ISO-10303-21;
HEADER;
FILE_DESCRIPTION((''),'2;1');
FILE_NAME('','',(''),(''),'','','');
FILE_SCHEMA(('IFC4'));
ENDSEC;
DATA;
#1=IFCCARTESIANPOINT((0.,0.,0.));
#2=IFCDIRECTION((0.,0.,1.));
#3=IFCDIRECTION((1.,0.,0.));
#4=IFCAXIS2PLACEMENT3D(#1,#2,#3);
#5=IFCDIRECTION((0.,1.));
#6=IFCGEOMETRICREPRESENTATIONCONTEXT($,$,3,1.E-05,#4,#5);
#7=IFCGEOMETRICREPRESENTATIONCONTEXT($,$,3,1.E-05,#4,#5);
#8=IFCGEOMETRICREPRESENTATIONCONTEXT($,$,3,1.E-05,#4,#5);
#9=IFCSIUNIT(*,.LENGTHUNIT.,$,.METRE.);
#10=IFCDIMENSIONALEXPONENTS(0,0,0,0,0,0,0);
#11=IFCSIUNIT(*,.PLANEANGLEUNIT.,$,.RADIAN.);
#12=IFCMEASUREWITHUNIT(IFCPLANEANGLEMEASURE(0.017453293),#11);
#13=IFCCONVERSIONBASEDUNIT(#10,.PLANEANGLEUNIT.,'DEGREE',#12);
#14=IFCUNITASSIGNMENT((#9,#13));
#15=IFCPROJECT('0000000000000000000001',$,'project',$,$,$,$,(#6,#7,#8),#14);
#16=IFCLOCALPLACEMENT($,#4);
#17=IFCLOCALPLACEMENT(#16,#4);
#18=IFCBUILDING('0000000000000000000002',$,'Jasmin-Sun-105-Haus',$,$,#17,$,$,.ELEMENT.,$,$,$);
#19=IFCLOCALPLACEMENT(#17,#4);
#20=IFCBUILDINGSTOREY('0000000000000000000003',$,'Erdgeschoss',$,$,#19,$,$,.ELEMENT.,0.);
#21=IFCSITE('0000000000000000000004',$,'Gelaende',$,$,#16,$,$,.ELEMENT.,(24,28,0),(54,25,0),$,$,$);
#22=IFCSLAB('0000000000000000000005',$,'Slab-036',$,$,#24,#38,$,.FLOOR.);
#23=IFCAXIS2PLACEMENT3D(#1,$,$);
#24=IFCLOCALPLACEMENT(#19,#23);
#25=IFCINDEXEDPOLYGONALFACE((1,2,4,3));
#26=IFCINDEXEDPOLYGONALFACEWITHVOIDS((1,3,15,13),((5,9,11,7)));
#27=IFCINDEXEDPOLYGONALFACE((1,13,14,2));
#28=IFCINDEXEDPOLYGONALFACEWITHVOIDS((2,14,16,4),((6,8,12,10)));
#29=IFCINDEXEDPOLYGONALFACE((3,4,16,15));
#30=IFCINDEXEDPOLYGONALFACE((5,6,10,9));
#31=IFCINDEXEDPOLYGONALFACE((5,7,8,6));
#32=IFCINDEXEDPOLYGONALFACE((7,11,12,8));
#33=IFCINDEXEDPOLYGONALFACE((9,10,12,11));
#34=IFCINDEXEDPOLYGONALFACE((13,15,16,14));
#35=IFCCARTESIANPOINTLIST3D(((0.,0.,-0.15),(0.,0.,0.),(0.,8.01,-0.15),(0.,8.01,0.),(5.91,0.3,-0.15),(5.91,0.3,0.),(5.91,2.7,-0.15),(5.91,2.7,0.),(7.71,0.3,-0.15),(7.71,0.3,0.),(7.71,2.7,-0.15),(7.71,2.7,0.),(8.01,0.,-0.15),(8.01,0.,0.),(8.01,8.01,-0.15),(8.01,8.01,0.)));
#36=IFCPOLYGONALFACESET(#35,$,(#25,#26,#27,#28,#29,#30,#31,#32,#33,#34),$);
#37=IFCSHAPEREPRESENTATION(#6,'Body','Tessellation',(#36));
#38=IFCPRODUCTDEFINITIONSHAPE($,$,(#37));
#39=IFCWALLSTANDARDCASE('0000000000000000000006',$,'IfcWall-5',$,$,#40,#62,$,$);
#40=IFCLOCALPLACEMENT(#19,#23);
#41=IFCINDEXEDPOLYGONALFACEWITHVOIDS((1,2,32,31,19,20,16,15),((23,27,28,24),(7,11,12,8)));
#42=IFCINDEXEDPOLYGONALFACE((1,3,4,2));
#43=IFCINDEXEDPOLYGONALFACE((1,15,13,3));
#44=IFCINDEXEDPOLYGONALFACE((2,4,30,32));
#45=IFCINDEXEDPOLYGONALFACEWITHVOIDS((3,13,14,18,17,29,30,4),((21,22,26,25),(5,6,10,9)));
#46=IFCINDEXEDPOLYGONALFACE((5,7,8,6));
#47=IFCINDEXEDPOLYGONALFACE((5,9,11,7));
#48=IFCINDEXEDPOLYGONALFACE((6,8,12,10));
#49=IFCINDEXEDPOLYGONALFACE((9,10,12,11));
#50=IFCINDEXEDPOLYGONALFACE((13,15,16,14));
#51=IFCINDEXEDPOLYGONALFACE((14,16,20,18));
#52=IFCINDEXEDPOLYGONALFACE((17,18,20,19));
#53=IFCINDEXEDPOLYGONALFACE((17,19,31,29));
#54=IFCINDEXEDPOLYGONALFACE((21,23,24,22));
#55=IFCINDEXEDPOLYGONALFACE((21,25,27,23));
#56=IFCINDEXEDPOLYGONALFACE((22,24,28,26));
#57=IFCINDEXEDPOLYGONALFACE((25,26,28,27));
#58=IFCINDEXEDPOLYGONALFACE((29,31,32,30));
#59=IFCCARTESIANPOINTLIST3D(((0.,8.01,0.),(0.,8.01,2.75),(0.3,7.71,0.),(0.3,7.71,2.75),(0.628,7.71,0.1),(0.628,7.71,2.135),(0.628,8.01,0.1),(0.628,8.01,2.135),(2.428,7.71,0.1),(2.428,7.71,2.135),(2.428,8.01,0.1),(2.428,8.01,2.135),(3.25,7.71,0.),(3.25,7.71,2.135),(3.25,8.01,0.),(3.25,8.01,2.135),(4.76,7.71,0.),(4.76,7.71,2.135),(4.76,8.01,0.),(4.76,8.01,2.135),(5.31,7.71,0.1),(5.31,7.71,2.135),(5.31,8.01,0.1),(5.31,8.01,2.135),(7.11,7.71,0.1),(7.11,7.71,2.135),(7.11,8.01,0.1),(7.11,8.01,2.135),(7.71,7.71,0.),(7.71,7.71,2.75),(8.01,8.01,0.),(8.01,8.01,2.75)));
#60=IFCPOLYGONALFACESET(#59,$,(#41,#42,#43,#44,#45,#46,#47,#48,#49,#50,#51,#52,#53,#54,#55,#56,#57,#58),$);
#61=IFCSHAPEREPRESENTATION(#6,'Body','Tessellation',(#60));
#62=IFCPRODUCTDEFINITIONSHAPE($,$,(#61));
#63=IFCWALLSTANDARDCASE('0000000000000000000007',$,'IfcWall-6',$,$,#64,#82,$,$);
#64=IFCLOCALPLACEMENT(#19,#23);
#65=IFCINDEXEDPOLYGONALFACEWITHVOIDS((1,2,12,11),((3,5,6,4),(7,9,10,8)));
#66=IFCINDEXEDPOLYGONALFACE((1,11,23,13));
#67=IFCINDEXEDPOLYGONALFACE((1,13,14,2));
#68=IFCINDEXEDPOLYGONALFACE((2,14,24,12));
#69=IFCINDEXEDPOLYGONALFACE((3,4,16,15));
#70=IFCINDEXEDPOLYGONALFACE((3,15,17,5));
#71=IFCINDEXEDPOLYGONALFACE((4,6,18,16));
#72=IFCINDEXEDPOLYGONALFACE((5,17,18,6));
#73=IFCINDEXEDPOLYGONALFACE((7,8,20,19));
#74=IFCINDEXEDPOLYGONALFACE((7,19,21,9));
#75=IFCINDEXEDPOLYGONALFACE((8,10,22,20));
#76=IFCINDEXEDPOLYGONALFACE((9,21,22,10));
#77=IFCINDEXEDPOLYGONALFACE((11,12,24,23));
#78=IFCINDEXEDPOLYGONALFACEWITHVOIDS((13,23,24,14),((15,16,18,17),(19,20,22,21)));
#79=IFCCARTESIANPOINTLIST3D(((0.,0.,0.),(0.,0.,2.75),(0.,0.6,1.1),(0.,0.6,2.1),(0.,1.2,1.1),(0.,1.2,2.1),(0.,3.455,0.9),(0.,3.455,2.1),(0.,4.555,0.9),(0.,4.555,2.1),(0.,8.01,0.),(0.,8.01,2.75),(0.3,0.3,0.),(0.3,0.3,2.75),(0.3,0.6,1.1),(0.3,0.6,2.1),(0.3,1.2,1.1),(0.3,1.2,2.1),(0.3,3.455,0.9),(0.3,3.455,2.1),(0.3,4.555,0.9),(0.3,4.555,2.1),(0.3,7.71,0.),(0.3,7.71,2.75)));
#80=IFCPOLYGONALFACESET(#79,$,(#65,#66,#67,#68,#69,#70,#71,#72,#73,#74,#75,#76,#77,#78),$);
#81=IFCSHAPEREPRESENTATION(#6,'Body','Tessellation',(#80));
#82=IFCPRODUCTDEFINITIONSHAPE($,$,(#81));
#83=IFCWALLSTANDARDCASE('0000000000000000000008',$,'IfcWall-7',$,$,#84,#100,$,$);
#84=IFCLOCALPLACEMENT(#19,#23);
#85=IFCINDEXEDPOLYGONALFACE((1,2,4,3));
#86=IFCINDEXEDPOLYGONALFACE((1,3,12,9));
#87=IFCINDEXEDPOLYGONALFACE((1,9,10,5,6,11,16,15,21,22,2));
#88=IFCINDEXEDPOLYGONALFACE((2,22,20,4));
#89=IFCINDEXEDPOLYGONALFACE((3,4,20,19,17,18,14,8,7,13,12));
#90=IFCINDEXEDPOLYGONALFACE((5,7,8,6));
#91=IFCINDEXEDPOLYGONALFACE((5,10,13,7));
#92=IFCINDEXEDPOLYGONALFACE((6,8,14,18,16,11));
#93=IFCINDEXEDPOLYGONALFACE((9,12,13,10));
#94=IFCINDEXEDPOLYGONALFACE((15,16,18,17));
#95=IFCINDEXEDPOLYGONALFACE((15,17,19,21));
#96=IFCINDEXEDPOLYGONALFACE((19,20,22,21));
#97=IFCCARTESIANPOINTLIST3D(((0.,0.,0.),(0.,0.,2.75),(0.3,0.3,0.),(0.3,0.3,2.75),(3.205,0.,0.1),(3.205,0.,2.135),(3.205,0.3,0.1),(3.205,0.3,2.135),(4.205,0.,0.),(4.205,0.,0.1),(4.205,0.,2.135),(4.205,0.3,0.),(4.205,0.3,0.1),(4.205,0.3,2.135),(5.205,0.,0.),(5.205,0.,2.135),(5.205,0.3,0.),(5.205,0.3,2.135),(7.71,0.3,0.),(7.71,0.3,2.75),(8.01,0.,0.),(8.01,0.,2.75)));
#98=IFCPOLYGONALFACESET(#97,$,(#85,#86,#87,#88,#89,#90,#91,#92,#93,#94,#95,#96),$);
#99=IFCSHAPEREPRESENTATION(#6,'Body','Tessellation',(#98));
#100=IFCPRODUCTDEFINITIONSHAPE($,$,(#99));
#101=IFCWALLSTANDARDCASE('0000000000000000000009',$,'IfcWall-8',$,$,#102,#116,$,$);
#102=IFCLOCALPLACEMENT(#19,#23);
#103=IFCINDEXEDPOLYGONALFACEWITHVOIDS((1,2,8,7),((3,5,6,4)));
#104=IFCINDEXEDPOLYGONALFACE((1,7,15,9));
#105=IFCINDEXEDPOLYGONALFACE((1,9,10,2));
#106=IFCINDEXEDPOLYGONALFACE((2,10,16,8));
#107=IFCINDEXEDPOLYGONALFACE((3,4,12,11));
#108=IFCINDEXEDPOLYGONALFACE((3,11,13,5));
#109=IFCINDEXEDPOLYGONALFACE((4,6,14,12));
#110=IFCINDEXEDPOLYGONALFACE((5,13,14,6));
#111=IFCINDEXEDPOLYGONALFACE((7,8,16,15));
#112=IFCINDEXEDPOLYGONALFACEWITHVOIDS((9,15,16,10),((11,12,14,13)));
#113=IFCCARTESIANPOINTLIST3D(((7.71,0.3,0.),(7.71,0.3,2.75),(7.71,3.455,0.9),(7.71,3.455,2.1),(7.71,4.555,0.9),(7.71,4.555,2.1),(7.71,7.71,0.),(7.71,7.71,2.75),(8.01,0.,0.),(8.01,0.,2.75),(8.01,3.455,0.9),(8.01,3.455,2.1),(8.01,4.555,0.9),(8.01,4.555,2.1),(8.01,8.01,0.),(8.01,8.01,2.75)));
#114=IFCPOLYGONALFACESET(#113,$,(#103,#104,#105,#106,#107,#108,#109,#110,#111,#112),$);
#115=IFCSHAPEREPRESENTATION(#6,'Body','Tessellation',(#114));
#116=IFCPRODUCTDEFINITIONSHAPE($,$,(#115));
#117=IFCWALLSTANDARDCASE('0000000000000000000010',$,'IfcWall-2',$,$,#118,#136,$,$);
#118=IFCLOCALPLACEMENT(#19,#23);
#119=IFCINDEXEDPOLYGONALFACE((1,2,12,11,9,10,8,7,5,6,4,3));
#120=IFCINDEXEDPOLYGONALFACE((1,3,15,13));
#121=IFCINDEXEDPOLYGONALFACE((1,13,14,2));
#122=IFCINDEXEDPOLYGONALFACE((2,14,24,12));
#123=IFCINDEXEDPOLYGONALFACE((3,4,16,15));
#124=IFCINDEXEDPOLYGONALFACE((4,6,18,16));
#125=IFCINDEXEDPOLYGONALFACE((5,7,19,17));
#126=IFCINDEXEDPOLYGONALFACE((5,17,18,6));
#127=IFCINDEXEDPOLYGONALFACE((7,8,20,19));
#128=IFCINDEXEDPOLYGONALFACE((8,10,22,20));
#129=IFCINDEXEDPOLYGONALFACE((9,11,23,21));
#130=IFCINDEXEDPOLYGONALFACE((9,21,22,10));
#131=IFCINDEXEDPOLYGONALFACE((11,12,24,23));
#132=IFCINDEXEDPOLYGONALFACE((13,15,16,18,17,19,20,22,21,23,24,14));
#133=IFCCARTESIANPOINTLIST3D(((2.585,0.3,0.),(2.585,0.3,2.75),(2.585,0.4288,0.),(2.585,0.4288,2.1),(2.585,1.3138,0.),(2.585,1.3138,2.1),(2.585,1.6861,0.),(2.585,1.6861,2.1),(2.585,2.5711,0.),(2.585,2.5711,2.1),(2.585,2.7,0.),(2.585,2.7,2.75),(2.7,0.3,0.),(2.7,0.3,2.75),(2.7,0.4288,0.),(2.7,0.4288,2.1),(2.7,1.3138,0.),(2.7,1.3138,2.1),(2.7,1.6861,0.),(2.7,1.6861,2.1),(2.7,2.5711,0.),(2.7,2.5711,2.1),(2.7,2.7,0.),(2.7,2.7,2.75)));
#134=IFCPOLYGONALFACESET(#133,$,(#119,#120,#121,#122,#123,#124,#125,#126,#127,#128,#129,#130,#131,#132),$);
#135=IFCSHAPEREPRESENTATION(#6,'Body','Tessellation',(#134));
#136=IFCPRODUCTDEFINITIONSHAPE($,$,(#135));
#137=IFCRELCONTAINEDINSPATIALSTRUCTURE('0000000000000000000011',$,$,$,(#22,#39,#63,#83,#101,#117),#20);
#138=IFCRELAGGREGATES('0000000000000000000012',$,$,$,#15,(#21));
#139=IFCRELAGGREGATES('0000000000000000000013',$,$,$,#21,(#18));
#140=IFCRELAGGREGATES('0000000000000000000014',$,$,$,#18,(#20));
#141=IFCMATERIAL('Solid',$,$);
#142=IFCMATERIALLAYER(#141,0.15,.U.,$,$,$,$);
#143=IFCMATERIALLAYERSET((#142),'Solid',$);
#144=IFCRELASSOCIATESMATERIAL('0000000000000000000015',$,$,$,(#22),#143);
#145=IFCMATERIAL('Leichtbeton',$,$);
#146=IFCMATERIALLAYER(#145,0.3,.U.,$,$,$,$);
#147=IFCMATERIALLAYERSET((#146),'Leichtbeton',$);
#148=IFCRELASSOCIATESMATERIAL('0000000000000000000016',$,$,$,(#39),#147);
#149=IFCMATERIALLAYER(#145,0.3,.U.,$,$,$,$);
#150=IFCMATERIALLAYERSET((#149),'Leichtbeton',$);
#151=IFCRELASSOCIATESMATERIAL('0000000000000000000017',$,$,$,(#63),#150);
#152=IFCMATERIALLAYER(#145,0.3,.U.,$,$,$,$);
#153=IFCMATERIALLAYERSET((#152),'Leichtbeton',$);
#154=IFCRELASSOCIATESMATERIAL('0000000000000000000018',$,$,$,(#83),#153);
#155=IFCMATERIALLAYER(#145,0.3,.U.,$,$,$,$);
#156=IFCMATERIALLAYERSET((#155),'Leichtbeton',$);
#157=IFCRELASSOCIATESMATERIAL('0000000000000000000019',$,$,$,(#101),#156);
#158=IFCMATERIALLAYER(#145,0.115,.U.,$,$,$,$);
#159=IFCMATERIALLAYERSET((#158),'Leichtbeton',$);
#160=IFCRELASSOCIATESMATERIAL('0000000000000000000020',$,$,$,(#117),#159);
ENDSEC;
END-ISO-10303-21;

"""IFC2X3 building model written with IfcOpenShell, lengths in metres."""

from ifc_helpers import new_model, entity, si_unit, converted_unit, direction, frame, frame_2d, origin_with_axes, place, context, project, spatial, polyline, rectangle, outline, extrude, material, layer, layer_set, layer_usage, element, save


model = new_model("IFC2X3")

# Units and contexts
context_of_model_1 = context(None, 3, precision=1e-05, world=origin_with_axes(), true_north=direction((0.0, 1.0)))
context_of_model_2 = context(None, 3, precision=1e-05, world=origin_with_axes(), true_north=direction((0.0, 1.0)))
context_of_model_3 = context(None, 3, precision=1e-05, world=origin_with_axes(), true_north=direction((0.0, 1.0)))
ifc_project = project(units=[si_unit("LENGTHUNIT", "METRE"), converted_unit("PLANEANGLEUNIT", "DEGREE", entity("IfcPlaneAngleMeasure", 0.017453293), si_unit("PLANEANGLEUNIT", "RADIAN"), dimensions=[0, 0, 0, 0, 0, 0, 0])], contexts=[context_of_model_1, context_of_model_2, context_of_model_3])

# Site, building, storey
site_placement = place(None, origin_with_axes())
site = spatial("IfcSite", under=ifc_project, at=site_placement, Name="Gelaende", CompositionType="ELEMENT", RefLatitude=(24, 28, 0), RefLongitude=(54, 25, 0))
building_placement = place(site_placement, origin_with_axes())
building = spatial("IfcBuilding", under=site, at=building_placement, Name="Jasmin-Sun-105-Haus", CompositionType="ELEMENT")
storey_placement = place(building_placement, origin_with_axes())
storey = spatial("IfcBuildingStorey", under=building, at=storey_placement, Name="Erdgeschoss", CompositionType="ELEMENT", Elevation=0.0)

# Slab, opening
ifc_material_1 = material(Name="Solid")
ifc_layer_1 = layer(ifc_material_1, 0.15, ventilated="UNKNOWN")
ifc_layer_set_1 = layer_set([ifc_layer_1], Name="Solid")
ifc_layer_usage_1 = layer_usage(ifc_layer_set_1, "AXIS3", "NEGATIVE", 0.15)
slab_placement = place(storey_placement, frame((0.0, 8.01, -0.15), z_axis=(0.0, 0.0, 1.0), x_axis=(1.0, 0.0, 0.0)))
slab = element("IfcSlab", 1, at=slab_placement, inside=storey, material=ifc_layer_usage_1, Name="Slab-036", PredefinedType="FLOOR", context=context_of_model_1, shape_type="SweptSolid", body=[
    extrude(outline(polyline([(0.0, 0.0), (8.01, 0.0), (8.01, -8.01), (0.0, -8.01), (0.0, 0.0)])), origin_with_axes(), (0.0, 0.0, 1.0), 0.15),
])
opening_1_placement = place(slab_placement, origin_with_axes())
element("IfcOpeningElement", 2, at=opening_1_placement, cuts=slab, context=context_of_model_1, shape_type="SweptSolid", body=[
    extrude(outline(polyline([(7.71, -5.31), (7.71, -7.71), (5.91, -7.71), (5.91, -5.31), (7.71, -5.31)])), origin_with_axes(), (0.0, 0.0, 1.0), 0.15),
])

# Walls, openings
ifc_material_2 = material(Name="Leichtbeton")
ifc_layer_2 = layer(ifc_material_2, 0.3, ventilated="UNKNOWN")
ifc_layer_set_2 = layer_set([ifc_layer_2], Name="Leichtbeton")
ifc_layer_usage_2 = layer_usage(ifc_layer_set_2, "AXIS2", "POSITIVE", 0.0)
wall_1_placement = place(storey_placement, frame((8.01, 8.01, 0.0), z_axis=(0.0, 0.0, 1.0), x_axis=(-1.0, 0.0, 0.0)))
wall_1 = element("IfcWallStandardCase", 3, at=wall_1_placement, inside=storey, material=ifc_layer_usage_2, Name="IfcWall-5", context=context_of_model_1, shape_type="SweptSolid", body=[
    extrude(outline(polyline([(0.0, 0.0), (8.01, 0.0), (7.71, 0.3), (0.3, 0.3), (0.0, 0.0)])), origin_with_axes(), (0.0, 0.0, 1.0), 2.75),
])
opening_2_placement = place(wall_1_placement, frame((4.005, 0.0, 0.0), z_axis=(0.0, 0.0, 1.0), x_axis=(1.0, 0.0, 0.0)))
element("IfcOpeningElement", 4, at=opening_2_placement, cuts=wall_1, context=context_of_model_1, shape_type="SweptSolid", body=[
    extrude(rectangle(XDim=2.135, YDim=1.51, at=frame_2d((0.0, 1.0675), x_axis=(0.0, -1.0))), frame((0.0, 0.0, 0.0), z_axis=(0.0, 1.0, 0.0), x_axis=(-1.0, 0.0, 0.0)), (0.0, 0.0, 1.0), 0.3),
])
opening_3_placement = place(wall_1_placement, frame((6.482, 0.0, 0.1), z_axis=(0.0, 0.0, 1.0), x_axis=(1.0, 0.0, 0.0)))
element("IfcOpeningElement", 5, at=opening_3_placement, cuts=wall_1, context=context_of_model_1, shape_type="SweptSolid", body=[
    extrude(rectangle(XDim=2.035, YDim=1.8, at=frame_2d((0.0, 1.0175), x_axis=(0.0, -1.0))), frame((0.0, 0.0, 0.0), z_axis=(0.0, 1.0, 0.0), x_axis=(-1.0, 0.0, 0.0)), (0.0, 0.0, 1.0), 0.3),
])
opening_4_placement = place(wall_1_placement, frame((1.8, 0.0, 0.1), z_axis=(0.0, 0.0, 1.0), x_axis=(1.0, 0.0, 0.0)))
element("IfcOpeningElement", 6, at=opening_4_placement, cuts=wall_1, context=context_of_model_1, shape_type="SweptSolid", body=[
    extrude(rectangle(XDim=2.035, YDim=1.8, at=frame_2d((0.0, 1.0175), x_axis=(0.0, -1.0))), frame((0.0, 0.0, 0.0), z_axis=(0.0, 1.0, 0.0), x_axis=(-1.0, 0.0, 0.0)), (0.0, 0.0, 1.0), 0.3),
])
ifc_layer_3 = layer(ifc_material_2, 0.3, ventilated="UNKNOWN")
ifc_layer_set_3 = layer_set([ifc_layer_3], Name="Leichtbeton")
ifc_layer_usage_3 = layer_usage(ifc_layer_set_3, "AXIS2", "POSITIVE", 0.0)
wall_2_placement = place(storey_placement, frame((0.0, 8.01, 0.0), z_axis=(0.0, 0.0, 1.0), x_axis=(0.0, -1.0, 0.0)))
wall_2 = element("IfcWallStandardCase", 7, at=wall_2_placement, inside=storey, material=ifc_layer_usage_3, Name="IfcWall-6", context=context_of_model_1, shape_type="SweptSolid", body=[
    extrude(outline(polyline([(0.0, 0.0), (8.01, 0.0), (7.71, 0.3), (0.3, 0.3), (0.0, 0.0)])), origin_with_axes(), (0.0, 0.0, 1.0), 2.75),
])
opening_5_placement = place(wall_2_placement, frame((4.005, 0.0, 0.9), z_axis=(0.0, 0.0, 1.0), x_axis=(1.0, 0.0, 0.0)))
element("IfcOpeningElement", 8, at=opening_5_placement, cuts=wall_2, context=context_of_model_1, shape_type="SweptSolid", body=[
    extrude(rectangle(XDim=1.2, YDim=1.1, at=frame_2d((0.0, 0.6), x_axis=(0.0, -1.0))), frame((0.0, 0.0, 0.0), z_axis=(0.0, 1.0, 0.0), x_axis=(-1.0, 0.0, 0.0)), (0.0, 0.0, 1.0), 0.3),
])
opening_6_placement = place(wall_2_placement, frame((7.11, 0.0, 1.1), z_axis=(0.0, 0.0, 1.0), x_axis=(1.0, 0.0, 0.0)))
element("IfcOpeningElement", 9, at=opening_6_placement, cuts=wall_2, context=context_of_model_1, shape_type="SweptSolid", body=[
    extrude(rectangle(XDim=1.0, YDim=0.6, at=frame_2d((0.0, 0.5), x_axis=(0.0, -1.0))), frame((0.0, 0.0, 0.0), z_axis=(0.0, 1.0, 0.0), x_axis=(-1.0, 0.0, 0.0)), (0.0, 0.0, 1.0), 0.3),
])
ifc_layer_4 = layer(ifc_material_2, 0.3, ventilated="UNKNOWN")
ifc_layer_set_4 = layer_set([ifc_layer_4], Name="Leichtbeton")
ifc_layer_usage_4 = layer_usage(ifc_layer_set_4, "AXIS2", "POSITIVE", 0.0)
wall_3_placement = place(storey_placement, origin_with_axes())
wall_3 = element("IfcWallStandardCase", 10, at=wall_3_placement, inside=storey, material=ifc_layer_usage_4, Name="IfcWall-7", context=context_of_model_1, shape_type="SweptSolid", body=[
    extrude(outline(polyline([(0.0, 0.0), (8.01, 0.0), (7.71, 0.3), (0.3, 0.3), (0.0, 0.0)])), origin_with_axes(), (0.0, 0.0, 1.0), 2.75),
])
opening_7_placement = place(wall_3_placement, frame((4.705, 0.0, 0.0), z_axis=(0.0, 0.0, 1.0), x_axis=(1.0, 0.0, 0.0)))
element("IfcOpeningElement", 11, at=opening_7_placement, cuts=wall_3, context=context_of_model_1, shape_type="SweptSolid", body=[
    extrude(rectangle(XDim=2.135, YDim=1.0, at=frame_2d((0.0, 1.0675), x_axis=(0.0, -1.0))), frame((0.0, 0.0, 0.0), z_axis=(0.0, 1.0, 0.0), x_axis=(-1.0, 0.0, 0.0)), (0.0, 0.0, 1.0), 0.3),
])
opening_8_placement = place(wall_3_placement, frame((3.705, 0.0, 0.1), z_axis=(0.0, 0.0, 1.0), x_axis=(1.0, 0.0, 0.0)))
element("IfcOpeningElement", 12, at=opening_8_placement, cuts=wall_3, context=context_of_model_1, shape_type="SweptSolid", body=[
    extrude(rectangle(XDim=2.035, YDim=1.0, at=frame_2d((0.0, 1.0175), x_axis=(0.0, 1.0))), frame((0.0, 0.0, 0.0), z_axis=(0.0, 1.0, 0.0), x_axis=(-1.0, 0.0, 0.0)), (0.0, 0.0, 1.0), 0.3),
])

# Wall, opening
ifc_layer_5 = layer(ifc_material_2, 0.3, ventilated="UNKNOWN")
ifc_layer_set_5 = layer_set([ifc_layer_5], Name="Leichtbeton")
ifc_layer_usage_5 = layer_usage(ifc_layer_set_5, "AXIS2", "POSITIVE", 0.0)
wall_4_placement = place(storey_placement, frame((8.01, 0.0, 0.0), z_axis=(0.0, 0.0, 1.0), x_axis=(0.0, 1.0, 0.0)))
wall_4 = element("IfcWallStandardCase", 13, at=wall_4_placement, inside=storey, material=ifc_layer_usage_5, Name="IfcWall-8", context=context_of_model_1, shape_type="SweptSolid", body=[
    extrude(outline(polyline([(0.0, 0.0), (8.01, 0.0), (7.71, 0.3), (0.3, 0.3), (0.0, 0.0)])), origin_with_axes(), (0.0, 0.0, 1.0), 2.75),
])
opening_9_placement = place(wall_4_placement, frame((4.005, 0.0, 0.9), z_axis=(0.0, 0.0, 1.0), x_axis=(1.0, 0.0, 0.0)))
element("IfcOpeningElement", 14, at=opening_9_placement, cuts=wall_4, context=context_of_model_1, shape_type="SweptSolid", body=[
    extrude(rectangle(XDim=1.2, YDim=1.1, at=frame_2d((0.0, 0.6), x_axis=(0.0, -1.0))), frame((0.0, 0.0, 0.0), z_axis=(0.0, 1.0, 0.0), x_axis=(-1.0, 0.0, 0.0)), (0.0, 0.0, 1.0), 0.3),
])

# Wall, openings
ifc_layer_6 = layer(ifc_material_2, 0.115, ventilated="UNKNOWN")
ifc_layer_set_6 = layer_set([ifc_layer_6], Name="Leichtbeton")
ifc_layer_usage_6 = layer_usage(ifc_layer_set_6, "AXIS2", "POSITIVE", 0.0)
wall_5_placement = place(storey_placement, frame((2.7, 0.0, 0.0), z_axis=(0.0, 0.0, 1.0), x_axis=(0.0, 1.0, 0.0)))
wall_5 = element("IfcWallStandardCase", 15, at=wall_5_placement, inside=storey, material=ifc_layer_usage_6, Name="IfcWall-2", context=context_of_model_1, shape_type="SweptSolid", body=[
    extrude(outline(polyline([(0.3, 0.0), (2.7, 0.0), (2.7, 0.115), (0.3, 0.115), (0.3, 0.0)])), origin_with_axes(), (0.0, 0.0, 1.0), 2.75),
])
opening_10_placement = place(wall_5_placement, frame((2.1286, 0.0, 0.0), z_axis=(0.0, 0.0, 1.0), x_axis=(1.0, 0.0, 0.0)))
element("IfcOpeningElement", 16, at=opening_10_placement, cuts=wall_5, context=context_of_model_1, shape_type="SweptSolid", body=[
    extrude(rectangle(XDim=2.1, YDim=0.885, at=frame_2d((0.0, 1.05), x_axis=(0.0, -1.0))), frame((0.0, 0.0, 0.0), z_axis=(0.0, 1.0, 0.0), x_axis=(-1.0, 0.0, 0.0)), (0.0, 0.0, 1.0), 0.115),
])
opening_11_placement = place(wall_5_placement, frame((0.8713, 0.0, 0.0), z_axis=(0.0, 0.0, 1.0), x_axis=(1.0, 0.0, 0.0)))
element("IfcOpeningElement", 17, at=opening_11_placement, cuts=wall_5, context=context_of_model_1, shape_type="SweptSolid", body=[
    extrude(rectangle(XDim=2.1, YDim=0.885, at=frame_2d((0.0, 1.05), x_axis=(0.0, -1.0))), frame((0.0, 0.0, 0.0), z_axis=(0.0, 1.0, 0.0), x_axis=(-1.0, 0.0, 0.0)), (0.0, 0.0, 1.0), 0.115),
])

save(model, "model.ifc")
